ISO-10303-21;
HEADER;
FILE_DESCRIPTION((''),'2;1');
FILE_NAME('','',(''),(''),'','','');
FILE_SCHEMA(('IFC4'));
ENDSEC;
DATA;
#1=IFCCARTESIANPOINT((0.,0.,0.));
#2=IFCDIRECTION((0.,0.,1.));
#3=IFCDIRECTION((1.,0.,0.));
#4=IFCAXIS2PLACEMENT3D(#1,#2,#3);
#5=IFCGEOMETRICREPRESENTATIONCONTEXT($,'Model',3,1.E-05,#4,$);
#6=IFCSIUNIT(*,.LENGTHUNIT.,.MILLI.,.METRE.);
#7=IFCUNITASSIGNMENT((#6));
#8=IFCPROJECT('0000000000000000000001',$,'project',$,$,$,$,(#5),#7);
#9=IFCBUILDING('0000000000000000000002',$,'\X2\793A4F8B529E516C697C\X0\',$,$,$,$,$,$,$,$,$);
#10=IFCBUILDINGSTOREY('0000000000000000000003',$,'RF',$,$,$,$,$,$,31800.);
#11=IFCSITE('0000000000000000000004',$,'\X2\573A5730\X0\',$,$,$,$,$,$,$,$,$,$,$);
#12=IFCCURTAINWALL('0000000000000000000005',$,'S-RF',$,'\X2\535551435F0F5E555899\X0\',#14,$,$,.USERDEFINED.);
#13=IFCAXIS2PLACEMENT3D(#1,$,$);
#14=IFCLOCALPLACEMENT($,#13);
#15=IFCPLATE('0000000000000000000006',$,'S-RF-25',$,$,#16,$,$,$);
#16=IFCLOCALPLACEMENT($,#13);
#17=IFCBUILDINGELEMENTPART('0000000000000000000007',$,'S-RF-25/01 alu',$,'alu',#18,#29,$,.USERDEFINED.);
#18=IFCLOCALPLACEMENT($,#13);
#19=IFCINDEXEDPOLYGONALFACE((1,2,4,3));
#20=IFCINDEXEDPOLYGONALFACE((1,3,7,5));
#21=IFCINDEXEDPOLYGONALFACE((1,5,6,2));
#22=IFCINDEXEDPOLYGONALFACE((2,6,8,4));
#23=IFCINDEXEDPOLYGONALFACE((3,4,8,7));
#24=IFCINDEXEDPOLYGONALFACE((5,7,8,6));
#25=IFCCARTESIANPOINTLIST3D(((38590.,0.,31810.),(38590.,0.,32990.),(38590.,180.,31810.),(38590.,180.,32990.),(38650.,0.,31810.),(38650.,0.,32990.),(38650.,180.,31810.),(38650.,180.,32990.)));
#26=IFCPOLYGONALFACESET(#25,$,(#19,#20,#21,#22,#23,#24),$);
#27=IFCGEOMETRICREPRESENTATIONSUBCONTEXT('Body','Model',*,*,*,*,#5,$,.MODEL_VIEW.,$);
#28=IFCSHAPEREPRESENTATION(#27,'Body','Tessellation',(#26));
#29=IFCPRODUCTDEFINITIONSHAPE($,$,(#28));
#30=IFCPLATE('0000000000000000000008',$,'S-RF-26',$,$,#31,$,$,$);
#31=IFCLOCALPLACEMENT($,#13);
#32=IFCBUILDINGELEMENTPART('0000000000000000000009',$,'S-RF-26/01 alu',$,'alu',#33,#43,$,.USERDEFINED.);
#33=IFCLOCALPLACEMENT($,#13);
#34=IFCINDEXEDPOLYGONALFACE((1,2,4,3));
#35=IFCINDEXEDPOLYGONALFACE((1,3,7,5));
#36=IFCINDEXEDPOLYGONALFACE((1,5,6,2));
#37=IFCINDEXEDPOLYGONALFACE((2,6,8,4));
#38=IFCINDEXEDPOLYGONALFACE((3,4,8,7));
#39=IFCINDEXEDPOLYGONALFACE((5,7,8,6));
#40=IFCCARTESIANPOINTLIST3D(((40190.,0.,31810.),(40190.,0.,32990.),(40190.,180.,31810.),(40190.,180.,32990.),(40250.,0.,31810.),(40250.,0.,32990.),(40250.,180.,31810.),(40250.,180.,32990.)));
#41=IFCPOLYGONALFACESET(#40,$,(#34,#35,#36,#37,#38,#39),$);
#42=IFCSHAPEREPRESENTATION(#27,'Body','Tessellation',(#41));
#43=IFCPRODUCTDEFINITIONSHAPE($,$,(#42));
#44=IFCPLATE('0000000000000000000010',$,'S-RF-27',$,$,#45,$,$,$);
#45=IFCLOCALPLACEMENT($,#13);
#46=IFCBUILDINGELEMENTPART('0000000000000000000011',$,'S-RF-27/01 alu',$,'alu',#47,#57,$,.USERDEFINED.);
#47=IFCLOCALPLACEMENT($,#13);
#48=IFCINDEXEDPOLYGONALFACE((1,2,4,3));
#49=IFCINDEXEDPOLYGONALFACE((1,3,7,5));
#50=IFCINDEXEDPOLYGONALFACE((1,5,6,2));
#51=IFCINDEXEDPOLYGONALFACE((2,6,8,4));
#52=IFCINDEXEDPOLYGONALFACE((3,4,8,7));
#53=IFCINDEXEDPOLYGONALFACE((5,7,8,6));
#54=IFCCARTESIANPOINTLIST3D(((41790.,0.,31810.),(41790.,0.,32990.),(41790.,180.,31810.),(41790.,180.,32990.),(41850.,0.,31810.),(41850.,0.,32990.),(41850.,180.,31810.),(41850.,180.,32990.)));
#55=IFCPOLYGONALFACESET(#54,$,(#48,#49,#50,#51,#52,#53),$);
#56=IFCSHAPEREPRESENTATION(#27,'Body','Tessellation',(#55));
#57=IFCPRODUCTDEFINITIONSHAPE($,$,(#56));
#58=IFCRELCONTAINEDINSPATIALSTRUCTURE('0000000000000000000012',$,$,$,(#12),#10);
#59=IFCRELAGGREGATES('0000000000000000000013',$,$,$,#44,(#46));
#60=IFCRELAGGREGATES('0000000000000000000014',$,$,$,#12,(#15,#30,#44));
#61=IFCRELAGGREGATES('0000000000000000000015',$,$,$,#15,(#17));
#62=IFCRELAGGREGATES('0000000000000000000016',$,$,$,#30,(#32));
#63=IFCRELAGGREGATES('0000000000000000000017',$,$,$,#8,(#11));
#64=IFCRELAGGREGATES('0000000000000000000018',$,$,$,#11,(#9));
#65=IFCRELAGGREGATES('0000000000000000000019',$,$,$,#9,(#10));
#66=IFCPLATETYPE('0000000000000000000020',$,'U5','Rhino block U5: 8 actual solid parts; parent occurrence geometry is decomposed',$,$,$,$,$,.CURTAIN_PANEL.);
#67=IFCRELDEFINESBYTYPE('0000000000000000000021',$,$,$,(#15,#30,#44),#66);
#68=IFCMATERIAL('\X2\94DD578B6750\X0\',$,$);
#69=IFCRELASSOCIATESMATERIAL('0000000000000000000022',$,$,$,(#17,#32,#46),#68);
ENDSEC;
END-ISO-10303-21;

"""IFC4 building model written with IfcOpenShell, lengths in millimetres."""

from ifc_helpers import new_model, si_unit, frame, frame_2d, origin, origin_with_axes, place, context, subcontext, project, spatial, rectangle, extrude, source, transform, mapped, material, type_object, element, aggregate, save


model = new_model("IFC4")

# Units and contexts
model_context = context("Model", 3, precision=1e-05, world=origin_with_axes())
body_context = subcontext(model_context, "Body", "Model", "MODEL_VIEW")
ifc_project = project(units=[si_unit("LENGTHUNIT", "METRE", prefix="MILLI")], contexts=[model_context])

# Site, building, storey
site = spatial("IfcSite", under=ifc_project, Name="场地")
building = spatial("IfcBuilding", under=site, Name="示例办公楼")
storey = spatial("IfcBuildingStorey", under=building, Name="RF", Elevation=31800.0)

# Curtain wall, plates, building element parts
curtain_wall = element("IfcCurtainWall", 1, inside=storey, Name="S-RF", ObjectType="单元式幕墙", PredefinedType="USERDEFINED")
plate_type = type_object("IfcPlateType", Name="U5", Description="Rhino block U5: 8 actual solid parts; parent occurrence geometry is decomposed", PredefinedType="CURTAIN_PANEL")
plate_1_placement = place(None, frame((38590.0, 0.0, 31810.0), z_axis=(0.0, 0.0, 1.0), x_axis=(1.0, 0.0, 0.0)))
plate_1 = element("IfcPlate", 2, at=plate_1_placement, type_object=plate_type, Name="S-RF-25")
ifc_material_1 = material(Name="铝型材")
shared_shape_1 = source(origin(), body_context, "Body", "SweptSolid", [
    extrude(rectangle(XDim=60.0, YDim=180.0, at=frame_2d((30.0, 90.0))), origin(), (0.0, 0.0, 1.0), 1180.0),
])
building_element_part_1_placement = place(plate_1_placement, origin())
building_element_part_1 = element("IfcBuildingElementPart", 3, at=building_element_part_1_placement, material=ifc_material_1, Name="S-RF-25/01 alu", ObjectType="alu", PredefinedType="USERDEFINED", context=body_context, shape_type="MappedRepresentation", body=[
    mapped(shared_shape_1, transform((0.0, 0.0, 0.0))),
])
plate_2_placement = place(None, frame((40190.0, 0.0, 31810.0), z_axis=(0.0, 0.0, 1.0), x_axis=(1.0, 0.0, 0.0)))
plate_2 = element("IfcPlate", 4, at=plate_2_placement, type_object=plate_type, Name="S-RF-26")
building_element_part_2_placement = place(plate_2_placement, origin())
building_element_part_2 = element("IfcBuildingElementPart", 5, at=building_element_part_2_placement, material=ifc_material_1, Name="S-RF-26/01 alu", ObjectType="alu", PredefinedType="USERDEFINED", context=body_context, shape_type="MappedRepresentation", body=[
    mapped(shared_shape_1, transform((0.0, 0.0, 0.0))),
])
plate_3_placement = place(None, frame((41790.0, 0.0, 31810.0), z_axis=(0.0, 0.0, 1.0), x_axis=(1.0, 0.0, 0.0)))
plate_3 = element("IfcPlate", 6, at=plate_3_placement, type_object=plate_type, Name="S-RF-27")
building_element_part_3_placement = place(plate_3_placement, origin())
building_element_part_3 = element("IfcBuildingElementPart", 7, at=building_element_part_3_placement, material=ifc_material_1, Name="S-RF-27/01 alu", ObjectType="alu", PredefinedType="USERDEFINED", context=body_context, shape_type="MappedRepresentation", body=[
    mapped(shared_shape_1, transform((0.0, 0.0, 0.0))),
])
aggregate(plate_3, [building_element_part_3])
aggregate(curtain_wall, [plate_1, plate_2, plate_3])
aggregate(plate_1, [building_element_part_1])
aggregate(plate_2, [building_element_part_2])

save(model, "model.ifc")
